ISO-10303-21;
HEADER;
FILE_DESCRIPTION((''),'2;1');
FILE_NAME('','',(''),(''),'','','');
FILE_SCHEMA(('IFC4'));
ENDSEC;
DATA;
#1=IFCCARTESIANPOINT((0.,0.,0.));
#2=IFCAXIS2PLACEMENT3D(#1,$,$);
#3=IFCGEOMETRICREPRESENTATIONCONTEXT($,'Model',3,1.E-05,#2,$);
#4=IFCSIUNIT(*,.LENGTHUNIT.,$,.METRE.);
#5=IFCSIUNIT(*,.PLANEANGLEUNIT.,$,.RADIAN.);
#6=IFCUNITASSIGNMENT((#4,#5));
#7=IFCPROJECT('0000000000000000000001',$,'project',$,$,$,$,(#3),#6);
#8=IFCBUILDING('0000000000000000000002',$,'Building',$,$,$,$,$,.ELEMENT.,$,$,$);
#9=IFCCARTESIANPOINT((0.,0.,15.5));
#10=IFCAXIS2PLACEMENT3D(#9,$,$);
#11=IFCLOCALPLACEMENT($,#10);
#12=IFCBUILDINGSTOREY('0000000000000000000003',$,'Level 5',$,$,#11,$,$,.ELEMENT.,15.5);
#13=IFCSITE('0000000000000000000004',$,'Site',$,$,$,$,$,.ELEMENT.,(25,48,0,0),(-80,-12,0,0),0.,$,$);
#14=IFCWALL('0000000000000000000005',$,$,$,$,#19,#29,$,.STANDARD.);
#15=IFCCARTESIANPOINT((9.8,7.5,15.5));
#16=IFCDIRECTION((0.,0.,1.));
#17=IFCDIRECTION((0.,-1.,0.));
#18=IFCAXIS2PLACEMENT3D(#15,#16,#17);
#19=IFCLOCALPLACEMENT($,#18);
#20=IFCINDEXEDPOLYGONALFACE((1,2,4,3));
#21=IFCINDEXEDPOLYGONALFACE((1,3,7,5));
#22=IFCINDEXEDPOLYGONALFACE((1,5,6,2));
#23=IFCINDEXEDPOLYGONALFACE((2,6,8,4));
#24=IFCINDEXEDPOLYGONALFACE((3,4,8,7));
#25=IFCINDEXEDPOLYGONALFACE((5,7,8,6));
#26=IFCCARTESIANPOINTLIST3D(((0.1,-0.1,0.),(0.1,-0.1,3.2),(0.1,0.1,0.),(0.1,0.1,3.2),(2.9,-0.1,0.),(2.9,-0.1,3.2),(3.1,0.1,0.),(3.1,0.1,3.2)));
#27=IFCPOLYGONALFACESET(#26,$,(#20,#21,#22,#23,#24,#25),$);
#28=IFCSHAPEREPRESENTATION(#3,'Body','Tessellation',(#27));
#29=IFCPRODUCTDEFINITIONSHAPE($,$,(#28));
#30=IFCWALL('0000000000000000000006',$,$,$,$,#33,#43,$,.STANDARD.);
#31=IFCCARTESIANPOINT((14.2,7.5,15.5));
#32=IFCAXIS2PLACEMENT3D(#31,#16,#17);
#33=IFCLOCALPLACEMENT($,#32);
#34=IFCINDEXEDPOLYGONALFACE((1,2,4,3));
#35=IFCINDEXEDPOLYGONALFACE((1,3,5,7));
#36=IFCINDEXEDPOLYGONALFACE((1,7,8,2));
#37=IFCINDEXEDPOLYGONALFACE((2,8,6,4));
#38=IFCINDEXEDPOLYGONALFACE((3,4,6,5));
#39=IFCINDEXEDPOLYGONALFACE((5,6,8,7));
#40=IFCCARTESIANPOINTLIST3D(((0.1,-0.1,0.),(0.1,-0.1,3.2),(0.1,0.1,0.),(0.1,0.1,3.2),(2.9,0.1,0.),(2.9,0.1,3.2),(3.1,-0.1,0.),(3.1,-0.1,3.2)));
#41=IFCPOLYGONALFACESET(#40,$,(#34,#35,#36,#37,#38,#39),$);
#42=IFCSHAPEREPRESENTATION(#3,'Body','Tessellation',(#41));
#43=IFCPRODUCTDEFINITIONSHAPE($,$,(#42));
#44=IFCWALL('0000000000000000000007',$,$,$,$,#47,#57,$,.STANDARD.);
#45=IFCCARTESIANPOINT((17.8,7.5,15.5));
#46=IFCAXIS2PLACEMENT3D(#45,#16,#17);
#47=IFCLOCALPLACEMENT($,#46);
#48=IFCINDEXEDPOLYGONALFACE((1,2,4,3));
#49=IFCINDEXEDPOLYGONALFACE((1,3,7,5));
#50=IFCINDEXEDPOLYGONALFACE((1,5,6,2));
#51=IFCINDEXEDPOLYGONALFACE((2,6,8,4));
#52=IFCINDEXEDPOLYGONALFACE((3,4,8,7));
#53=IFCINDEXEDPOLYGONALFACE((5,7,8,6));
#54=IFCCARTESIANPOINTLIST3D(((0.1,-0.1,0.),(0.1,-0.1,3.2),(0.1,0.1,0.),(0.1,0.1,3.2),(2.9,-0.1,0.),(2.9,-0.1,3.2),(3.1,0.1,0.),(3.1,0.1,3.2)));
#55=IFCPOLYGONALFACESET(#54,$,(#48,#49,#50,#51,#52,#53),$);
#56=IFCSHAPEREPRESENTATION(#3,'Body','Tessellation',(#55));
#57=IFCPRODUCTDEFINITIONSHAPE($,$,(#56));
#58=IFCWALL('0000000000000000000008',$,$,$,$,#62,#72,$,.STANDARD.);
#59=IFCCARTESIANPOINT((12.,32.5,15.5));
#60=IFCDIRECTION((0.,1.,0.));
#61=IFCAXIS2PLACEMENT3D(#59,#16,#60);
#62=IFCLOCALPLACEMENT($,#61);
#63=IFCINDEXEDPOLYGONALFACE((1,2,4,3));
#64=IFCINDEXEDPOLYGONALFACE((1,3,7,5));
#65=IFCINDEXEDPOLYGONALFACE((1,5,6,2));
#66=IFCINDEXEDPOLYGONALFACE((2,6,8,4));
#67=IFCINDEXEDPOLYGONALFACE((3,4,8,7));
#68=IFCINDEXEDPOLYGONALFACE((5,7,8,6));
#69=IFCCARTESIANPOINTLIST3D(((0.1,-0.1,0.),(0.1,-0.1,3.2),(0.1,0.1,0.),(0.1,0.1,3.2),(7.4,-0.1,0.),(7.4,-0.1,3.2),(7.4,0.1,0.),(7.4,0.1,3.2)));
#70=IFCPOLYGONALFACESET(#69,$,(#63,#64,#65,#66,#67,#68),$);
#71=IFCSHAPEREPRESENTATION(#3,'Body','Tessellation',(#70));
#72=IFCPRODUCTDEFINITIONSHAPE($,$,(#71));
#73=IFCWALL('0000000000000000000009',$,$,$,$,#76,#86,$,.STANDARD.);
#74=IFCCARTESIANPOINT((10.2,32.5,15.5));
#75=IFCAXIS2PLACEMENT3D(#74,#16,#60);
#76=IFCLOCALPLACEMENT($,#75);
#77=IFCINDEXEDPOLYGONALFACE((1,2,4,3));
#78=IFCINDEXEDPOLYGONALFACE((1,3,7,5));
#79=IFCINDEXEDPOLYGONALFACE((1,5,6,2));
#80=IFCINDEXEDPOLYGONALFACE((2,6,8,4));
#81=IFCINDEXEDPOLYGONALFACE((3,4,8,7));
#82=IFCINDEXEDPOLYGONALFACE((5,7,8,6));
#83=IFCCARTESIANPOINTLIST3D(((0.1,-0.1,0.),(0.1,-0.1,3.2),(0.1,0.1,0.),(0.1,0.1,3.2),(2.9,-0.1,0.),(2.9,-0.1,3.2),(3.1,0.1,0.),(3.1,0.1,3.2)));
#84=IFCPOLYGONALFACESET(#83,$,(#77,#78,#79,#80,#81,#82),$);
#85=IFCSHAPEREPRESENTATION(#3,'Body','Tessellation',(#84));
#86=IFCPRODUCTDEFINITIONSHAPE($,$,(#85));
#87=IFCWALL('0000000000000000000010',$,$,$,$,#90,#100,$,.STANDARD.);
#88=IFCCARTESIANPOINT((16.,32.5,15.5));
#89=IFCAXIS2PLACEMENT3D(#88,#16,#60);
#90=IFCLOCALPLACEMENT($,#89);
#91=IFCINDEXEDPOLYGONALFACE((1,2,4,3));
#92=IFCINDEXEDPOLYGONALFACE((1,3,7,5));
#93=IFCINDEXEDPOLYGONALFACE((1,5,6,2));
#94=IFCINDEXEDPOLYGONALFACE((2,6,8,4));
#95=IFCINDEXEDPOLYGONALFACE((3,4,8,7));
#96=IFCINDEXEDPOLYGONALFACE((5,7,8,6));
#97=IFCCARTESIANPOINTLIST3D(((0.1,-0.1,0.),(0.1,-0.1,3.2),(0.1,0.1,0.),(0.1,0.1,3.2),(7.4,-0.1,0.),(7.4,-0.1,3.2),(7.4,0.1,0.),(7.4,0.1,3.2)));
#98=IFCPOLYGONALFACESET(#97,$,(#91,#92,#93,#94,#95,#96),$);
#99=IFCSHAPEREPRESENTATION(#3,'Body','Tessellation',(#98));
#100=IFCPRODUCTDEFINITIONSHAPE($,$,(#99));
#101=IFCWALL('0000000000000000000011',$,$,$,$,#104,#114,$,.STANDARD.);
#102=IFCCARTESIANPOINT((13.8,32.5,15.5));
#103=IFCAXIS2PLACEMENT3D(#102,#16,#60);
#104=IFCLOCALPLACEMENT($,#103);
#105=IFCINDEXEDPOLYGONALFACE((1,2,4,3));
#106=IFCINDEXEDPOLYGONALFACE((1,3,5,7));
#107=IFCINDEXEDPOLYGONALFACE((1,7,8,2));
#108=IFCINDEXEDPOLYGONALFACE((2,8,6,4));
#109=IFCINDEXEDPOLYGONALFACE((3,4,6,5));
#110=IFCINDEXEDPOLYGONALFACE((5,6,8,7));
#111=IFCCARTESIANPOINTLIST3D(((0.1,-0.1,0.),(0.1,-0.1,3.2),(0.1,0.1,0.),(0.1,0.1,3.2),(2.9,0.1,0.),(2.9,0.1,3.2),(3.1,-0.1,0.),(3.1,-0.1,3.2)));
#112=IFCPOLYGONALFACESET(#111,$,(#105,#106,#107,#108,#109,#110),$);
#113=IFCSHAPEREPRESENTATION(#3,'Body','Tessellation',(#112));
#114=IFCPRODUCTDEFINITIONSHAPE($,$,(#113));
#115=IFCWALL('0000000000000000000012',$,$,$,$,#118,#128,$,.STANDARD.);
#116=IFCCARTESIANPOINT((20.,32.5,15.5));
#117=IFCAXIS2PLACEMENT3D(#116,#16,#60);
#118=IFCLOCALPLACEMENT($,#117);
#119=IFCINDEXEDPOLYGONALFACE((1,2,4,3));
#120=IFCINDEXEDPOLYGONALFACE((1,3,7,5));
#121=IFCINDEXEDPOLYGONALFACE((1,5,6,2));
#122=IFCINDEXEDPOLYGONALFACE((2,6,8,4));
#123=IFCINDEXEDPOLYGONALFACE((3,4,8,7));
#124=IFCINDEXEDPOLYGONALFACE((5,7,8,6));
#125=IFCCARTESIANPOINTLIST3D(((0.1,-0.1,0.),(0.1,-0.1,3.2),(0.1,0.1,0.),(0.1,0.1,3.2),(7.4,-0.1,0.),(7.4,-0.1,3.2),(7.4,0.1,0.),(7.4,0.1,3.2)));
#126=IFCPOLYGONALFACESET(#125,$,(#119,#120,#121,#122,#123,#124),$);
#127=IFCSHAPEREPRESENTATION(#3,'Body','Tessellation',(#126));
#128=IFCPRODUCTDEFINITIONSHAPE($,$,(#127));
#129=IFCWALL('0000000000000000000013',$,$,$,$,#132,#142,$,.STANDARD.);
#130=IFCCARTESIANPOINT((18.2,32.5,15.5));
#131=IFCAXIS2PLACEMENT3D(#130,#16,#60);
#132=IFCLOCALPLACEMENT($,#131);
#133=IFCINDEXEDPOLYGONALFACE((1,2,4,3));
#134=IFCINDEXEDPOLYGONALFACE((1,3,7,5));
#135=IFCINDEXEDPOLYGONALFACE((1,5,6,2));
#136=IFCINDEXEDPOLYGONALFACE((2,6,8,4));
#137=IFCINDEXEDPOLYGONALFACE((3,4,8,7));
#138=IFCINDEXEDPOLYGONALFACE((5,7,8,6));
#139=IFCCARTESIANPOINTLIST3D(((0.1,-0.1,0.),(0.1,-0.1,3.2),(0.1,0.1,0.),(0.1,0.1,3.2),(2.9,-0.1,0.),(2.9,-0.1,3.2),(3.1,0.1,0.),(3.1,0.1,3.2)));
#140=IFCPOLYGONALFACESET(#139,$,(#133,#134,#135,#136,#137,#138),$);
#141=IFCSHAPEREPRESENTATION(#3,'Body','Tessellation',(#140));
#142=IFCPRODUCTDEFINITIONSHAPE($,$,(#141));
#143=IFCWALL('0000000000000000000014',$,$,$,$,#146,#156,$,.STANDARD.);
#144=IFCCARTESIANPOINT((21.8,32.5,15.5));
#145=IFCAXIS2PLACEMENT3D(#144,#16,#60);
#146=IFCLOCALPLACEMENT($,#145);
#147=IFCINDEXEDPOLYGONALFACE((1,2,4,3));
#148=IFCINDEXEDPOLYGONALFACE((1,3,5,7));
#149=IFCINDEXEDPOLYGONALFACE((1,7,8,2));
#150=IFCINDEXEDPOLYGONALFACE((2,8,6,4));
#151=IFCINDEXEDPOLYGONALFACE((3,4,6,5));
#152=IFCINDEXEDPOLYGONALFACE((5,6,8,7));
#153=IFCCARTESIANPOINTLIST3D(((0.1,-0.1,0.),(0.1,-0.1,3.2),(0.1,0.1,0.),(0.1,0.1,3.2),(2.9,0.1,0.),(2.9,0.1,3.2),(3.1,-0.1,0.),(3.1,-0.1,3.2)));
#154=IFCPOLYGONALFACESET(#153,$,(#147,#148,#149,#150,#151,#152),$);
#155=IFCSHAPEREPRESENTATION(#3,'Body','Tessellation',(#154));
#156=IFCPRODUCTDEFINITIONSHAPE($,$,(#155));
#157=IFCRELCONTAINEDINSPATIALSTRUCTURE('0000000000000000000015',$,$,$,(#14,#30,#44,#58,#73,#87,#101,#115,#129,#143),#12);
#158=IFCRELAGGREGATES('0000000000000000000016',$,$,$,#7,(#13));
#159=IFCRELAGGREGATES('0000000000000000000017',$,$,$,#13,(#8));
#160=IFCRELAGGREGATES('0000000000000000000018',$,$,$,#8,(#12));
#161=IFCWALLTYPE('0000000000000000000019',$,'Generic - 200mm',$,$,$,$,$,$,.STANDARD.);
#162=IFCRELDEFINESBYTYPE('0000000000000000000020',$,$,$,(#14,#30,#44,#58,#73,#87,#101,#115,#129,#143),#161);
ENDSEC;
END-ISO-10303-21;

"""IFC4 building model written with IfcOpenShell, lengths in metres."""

from ifc_helpers import new_model, si_unit, frame, origin, place, context, project, spatial, polyline, outline, extrude, type_object, element, save


model = new_model("IFC4")

# Units and contexts
model_context = context("Model", 3, precision=1e-05, world=origin())
ifc_project = project(units=[si_unit("LENGTHUNIT", "METRE"), si_unit("PLANEANGLEUNIT", "RADIAN")], contexts=[model_context])

# Site, building, storey
site = spatial("IfcSite", under=ifc_project, Name="Site", CompositionType="ELEMENT", RefLatitude=(25, 48, 0, 0), RefLongitude=(-80, -12, 0, 0), RefElevation=0.0)
building = spatial("IfcBuilding", under=site, Name="Building", CompositionType="ELEMENT")
storey_placement = place(None, frame((0.0, 0.0, 15.5)))
storey = spatial("IfcBuildingStorey", under=building, at=storey_placement, Name="Level 5", CompositionType="ELEMENT", Elevation=15.5)

# Shared definitions
wall_type = type_object("IfcWallType", Name="Generic - 200mm", PredefinedType="STANDARD")

# Walls
wall_1_placement = place(None, frame((9.8, 7.5, 15.5), z_axis=(0.0, 0.0, 1.0), x_axis=(0.0, -1.0, 0.0)))
element("IfcWall", 1, at=wall_1_placement, inside=storey, type_object=wall_type, PredefinedType="STANDARD", context=model_context, shape_type="SweptSolid", body=[
    extrude(outline(polyline([(0.1, -0.1), (2.9, -0.1), (3.1, 0.1), (0.1, 0.1), (0.1, -0.1)])), origin(), (0.0, 0.0, 1.0), 3.2),
])
wall_2_placement = place(None, frame((14.2, 7.5, 15.5), z_axis=(0.0, 0.0, 1.0), x_axis=(0.0, -1.0, 0.0)))
element("IfcWall", 2, at=wall_2_placement, inside=storey, type_object=wall_type, PredefinedType="STANDARD", context=model_context, shape_type="SweptSolid", body=[
    extrude(outline(polyline([(0.1, -0.1), (3.1, -0.1), (2.9, 0.1), (0.1, 0.1), (0.1, -0.1)])), origin(), (0.0, 0.0, 1.0), 3.2),
])
wall_3_placement = place(None, frame((17.8, 7.5, 15.5), z_axis=(0.0, 0.0, 1.0), x_axis=(0.0, -1.0, 0.0)))
element("IfcWall", 3, at=wall_3_placement, inside=storey, type_object=wall_type, PredefinedType="STANDARD", context=model_context, shape_type="SweptSolid", body=[
    extrude(outline(polyline([(0.1, -0.1), (2.9, -0.1), (3.1, 0.1), (0.1, 0.1), (0.1, -0.1)])), origin(), (0.0, 0.0, 1.0), 3.2),
])
wall_4_placement = place(None, frame((12.0, 32.5, 15.5), z_axis=(0.0, 0.0, 1.0), x_axis=(0.0, 1.0, 0.0)))
element("IfcWall", 4, at=wall_4_placement, inside=storey, type_object=wall_type, PredefinedType="STANDARD", context=model_context, shape_type="SweptSolid", body=[
    extrude(outline(polyline([(0.1, -0.1), (7.4, -0.1), (7.4, 0.1), (0.1, 0.1), (0.1, -0.1)])), origin(), (0.0, 0.0, 1.0), 3.2),
])
wall_5_placement = place(None, frame((10.2, 32.5, 15.5), z_axis=(0.0, 0.0, 1.0), x_axis=(0.0, 1.0, 0.0)))
element("IfcWall", 5, at=wall_5_placement, inside=storey, type_object=wall_type, PredefinedType="STANDARD", context=model_context, shape_type="SweptSolid", body=[
    extrude(outline(polyline([(0.1, -0.1), (2.9, -0.1), (3.1, 0.1), (0.1, 0.1), (0.1, -0.1)])), origin(), (0.0, 0.0, 1.0), 3.2),
])
wall_6_placement = place(None, frame((16.0, 32.5, 15.5), z_axis=(0.0, 0.0, 1.0), x_axis=(0.0, 1.0, 0.0)))
element("IfcWall", 6, at=wall_6_placement, inside=storey, type_object=wall_type, PredefinedType="STANDARD", context=model_context, shape_type="SweptSolid", body=[
    extrude(outline(polyline([(0.1, -0.1), (7.4, -0.1), (7.4, 0.1), (0.1, 0.1), (0.1, -0.1)])), origin(), (0.0, 0.0, 1.0), 3.2),
])
wall_7_placement = place(None, frame((13.8, 32.5, 15.5), z_axis=(0.0, 0.0, 1.0), x_axis=(0.0, 1.0, 0.0)))
element("IfcWall", 7, at=wall_7_placement, inside=storey, type_object=wall_type, PredefinedType="STANDARD", context=model_context, shape_type="SweptSolid", body=[
    extrude(outline(polyline([(0.1, -0.1), (3.1, -0.1), (2.9, 0.1), (0.1, 0.1), (0.1, -0.1)])), origin(), (0.0, 0.0, 1.0), 3.2),
])
wall_8_placement = place(None, frame((20.0, 32.5, 15.5), z_axis=(0.0, 0.0, 1.0), x_axis=(0.0, 1.0, 0.0)))
element("IfcWall", 8, at=wall_8_placement, inside=storey, type_object=wall_type, PredefinedType="STANDARD", context=model_context, shape_type="SweptSolid", body=[
    extrude(outline(polyline([(0.1, -0.1), (7.4, -0.1), (7.4, 0.1), (0.1, 0.1), (0.1, -0.1)])), origin(), (0.0, 0.0, 1.0), 3.2),
])
wall_9_placement = place(None, frame((18.2, 32.5, 15.5), z_axis=(0.0, 0.0, 1.0), x_axis=(0.0, 1.0, 0.0)))
element("IfcWall", 9, at=wall_9_placement, inside=storey, type_object=wall_type, PredefinedType="STANDARD", context=model_context, shape_type="SweptSolid", body=[
    extrude(outline(polyline([(0.1, -0.1), (2.9, -0.1), (3.1, 0.1), (0.1, 0.1), (0.1, -0.1)])), origin(), (0.0, 0.0, 1.0), 3.2),
])
wall_10_placement = place(None, frame((21.8, 32.5, 15.5), z_axis=(0.0, 0.0, 1.0), x_axis=(0.0, 1.0, 0.0)))
element("IfcWall", 10, at=wall_10_placement, inside=storey, type_object=wall_type, PredefinedType="STANDARD", context=model_context, shape_type="SweptSolid", body=[
    extrude(outline(polyline([(0.1, -0.1), (3.1, -0.1), (2.9, 0.1), (0.1, 0.1), (0.1, -0.1)])), origin(), (0.0, 0.0, 1.0), 3.2),
])

save(model, "model.ifc")
